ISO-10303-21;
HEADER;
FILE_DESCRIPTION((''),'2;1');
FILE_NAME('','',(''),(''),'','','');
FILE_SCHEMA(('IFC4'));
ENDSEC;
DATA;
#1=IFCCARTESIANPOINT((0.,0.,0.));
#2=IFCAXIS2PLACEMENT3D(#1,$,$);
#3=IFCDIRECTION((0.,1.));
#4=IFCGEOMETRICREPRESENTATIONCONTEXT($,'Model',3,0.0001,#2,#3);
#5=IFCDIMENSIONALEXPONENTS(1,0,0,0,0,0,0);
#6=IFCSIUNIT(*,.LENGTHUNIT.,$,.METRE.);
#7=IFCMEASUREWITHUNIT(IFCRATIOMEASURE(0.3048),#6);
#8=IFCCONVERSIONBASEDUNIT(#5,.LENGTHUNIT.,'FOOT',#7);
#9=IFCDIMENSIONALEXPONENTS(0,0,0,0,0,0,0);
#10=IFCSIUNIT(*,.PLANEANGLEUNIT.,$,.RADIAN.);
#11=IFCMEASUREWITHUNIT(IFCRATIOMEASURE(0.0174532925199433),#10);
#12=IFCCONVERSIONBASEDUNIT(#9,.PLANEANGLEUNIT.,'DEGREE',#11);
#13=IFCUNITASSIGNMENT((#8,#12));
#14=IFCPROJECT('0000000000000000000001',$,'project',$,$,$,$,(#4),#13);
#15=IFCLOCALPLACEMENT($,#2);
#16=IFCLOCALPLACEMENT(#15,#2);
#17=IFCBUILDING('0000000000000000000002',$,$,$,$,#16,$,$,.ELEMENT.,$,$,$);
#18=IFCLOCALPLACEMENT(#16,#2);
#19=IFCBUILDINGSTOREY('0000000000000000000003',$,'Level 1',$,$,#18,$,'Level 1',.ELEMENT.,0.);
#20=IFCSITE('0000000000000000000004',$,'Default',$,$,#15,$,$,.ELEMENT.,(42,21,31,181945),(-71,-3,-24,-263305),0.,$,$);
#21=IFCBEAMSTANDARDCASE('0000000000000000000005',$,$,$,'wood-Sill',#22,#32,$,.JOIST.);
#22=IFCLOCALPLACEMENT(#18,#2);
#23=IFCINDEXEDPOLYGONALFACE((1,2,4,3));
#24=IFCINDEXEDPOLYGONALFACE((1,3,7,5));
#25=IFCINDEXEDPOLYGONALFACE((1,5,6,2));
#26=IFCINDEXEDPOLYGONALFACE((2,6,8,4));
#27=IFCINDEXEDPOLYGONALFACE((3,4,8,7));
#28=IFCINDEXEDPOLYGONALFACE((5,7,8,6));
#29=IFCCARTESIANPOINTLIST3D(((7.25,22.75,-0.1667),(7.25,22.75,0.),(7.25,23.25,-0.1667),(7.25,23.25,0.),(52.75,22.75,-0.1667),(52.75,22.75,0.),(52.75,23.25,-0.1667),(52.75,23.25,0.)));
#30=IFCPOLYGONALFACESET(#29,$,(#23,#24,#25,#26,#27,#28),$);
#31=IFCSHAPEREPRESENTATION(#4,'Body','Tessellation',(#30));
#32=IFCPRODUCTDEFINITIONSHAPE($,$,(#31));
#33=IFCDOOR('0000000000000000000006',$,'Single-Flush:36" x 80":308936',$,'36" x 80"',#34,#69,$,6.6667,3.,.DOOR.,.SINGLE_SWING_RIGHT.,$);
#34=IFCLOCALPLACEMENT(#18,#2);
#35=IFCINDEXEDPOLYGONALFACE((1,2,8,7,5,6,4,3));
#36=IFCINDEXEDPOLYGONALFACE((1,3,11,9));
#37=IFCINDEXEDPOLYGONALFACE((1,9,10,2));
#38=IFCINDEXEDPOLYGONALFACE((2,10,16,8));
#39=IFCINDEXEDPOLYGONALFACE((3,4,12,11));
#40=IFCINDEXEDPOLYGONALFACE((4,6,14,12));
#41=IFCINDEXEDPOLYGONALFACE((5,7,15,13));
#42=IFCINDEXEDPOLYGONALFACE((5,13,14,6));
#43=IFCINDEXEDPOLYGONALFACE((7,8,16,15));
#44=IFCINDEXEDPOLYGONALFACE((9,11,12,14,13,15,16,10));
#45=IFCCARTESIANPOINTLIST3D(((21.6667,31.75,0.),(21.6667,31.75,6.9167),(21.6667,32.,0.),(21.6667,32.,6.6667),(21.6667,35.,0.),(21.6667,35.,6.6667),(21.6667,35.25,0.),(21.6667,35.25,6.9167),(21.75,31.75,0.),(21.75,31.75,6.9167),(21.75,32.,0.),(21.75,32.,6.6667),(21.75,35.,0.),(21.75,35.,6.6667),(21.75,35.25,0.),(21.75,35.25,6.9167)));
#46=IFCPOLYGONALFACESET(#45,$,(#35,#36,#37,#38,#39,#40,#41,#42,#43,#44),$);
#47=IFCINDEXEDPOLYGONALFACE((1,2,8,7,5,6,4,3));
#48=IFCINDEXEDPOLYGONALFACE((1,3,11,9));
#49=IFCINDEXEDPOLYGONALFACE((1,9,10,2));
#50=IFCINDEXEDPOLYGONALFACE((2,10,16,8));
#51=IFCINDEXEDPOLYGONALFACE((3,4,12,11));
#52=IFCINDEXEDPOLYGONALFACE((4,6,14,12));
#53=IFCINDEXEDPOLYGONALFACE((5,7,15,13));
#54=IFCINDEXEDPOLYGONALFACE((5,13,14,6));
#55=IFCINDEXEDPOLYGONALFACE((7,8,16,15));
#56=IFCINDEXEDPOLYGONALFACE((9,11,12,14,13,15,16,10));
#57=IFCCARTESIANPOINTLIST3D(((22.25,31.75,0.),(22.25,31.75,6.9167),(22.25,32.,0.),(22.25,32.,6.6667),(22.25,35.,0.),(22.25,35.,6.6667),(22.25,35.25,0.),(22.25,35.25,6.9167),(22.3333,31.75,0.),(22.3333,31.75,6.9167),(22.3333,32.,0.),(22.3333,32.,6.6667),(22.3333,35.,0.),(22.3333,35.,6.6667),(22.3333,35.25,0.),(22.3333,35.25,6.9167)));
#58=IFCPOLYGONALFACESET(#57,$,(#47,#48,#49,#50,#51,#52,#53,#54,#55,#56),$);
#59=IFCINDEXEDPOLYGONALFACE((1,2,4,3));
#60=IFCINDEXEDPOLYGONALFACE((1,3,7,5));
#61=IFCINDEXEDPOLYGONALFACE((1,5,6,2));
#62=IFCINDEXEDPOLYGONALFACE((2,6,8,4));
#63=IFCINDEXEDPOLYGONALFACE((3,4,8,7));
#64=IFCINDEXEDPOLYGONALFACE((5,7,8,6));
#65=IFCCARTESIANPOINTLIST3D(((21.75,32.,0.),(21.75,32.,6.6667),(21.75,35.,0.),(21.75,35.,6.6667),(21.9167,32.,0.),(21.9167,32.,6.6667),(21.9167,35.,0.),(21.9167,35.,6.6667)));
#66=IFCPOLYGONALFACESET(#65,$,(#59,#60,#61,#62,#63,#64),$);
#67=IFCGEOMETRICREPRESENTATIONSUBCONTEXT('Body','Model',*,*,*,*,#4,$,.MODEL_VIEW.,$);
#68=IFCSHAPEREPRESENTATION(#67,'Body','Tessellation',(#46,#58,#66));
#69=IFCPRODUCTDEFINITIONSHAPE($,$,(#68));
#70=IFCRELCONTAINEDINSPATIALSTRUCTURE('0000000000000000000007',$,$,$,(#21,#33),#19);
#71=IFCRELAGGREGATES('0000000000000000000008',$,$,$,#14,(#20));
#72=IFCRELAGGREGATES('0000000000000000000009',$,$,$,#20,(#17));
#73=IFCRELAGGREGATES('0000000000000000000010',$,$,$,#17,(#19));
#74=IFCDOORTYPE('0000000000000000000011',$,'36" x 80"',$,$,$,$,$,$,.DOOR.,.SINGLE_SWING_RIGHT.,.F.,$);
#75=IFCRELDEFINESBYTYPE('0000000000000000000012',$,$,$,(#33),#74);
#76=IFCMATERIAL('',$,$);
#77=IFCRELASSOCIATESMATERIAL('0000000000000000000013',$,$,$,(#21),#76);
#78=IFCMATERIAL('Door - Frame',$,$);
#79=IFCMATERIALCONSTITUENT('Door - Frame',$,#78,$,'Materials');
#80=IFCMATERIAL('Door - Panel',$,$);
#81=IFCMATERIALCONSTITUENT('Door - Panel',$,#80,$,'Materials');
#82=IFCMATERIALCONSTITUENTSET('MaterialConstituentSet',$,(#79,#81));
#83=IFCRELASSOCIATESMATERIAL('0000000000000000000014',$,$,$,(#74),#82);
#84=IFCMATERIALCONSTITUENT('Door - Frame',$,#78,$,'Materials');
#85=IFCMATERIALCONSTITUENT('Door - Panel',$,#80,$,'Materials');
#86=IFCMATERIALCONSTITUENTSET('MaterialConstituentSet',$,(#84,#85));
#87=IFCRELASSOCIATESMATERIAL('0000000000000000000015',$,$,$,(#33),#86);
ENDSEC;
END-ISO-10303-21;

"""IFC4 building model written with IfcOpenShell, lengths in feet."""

from ifc_helpers import new_model, entity, si_unit, converted_unit, direction, frame, origin, origin_2d_with_axis, place, context, subcontext, project, spatial, polyline, rectangle, outline, extrude, source, transform, mapped, material, constituent, constituent_set, type_object, type_shapes, element, save


model = new_model("IFC4")

# Units and contexts
model_context = context("Model", 3, precision=0.0001, world=origin(), true_north=direction((0.0, 1.0)))
body_context = subcontext(model_context, "Body", "Model", "MODEL_VIEW")
ifc_project = project(units=[converted_unit("LENGTHUNIT", "FOOT", entity("IfcRatioMeasure", 0.3048), si_unit("LENGTHUNIT", "METRE"), dimensions=[1, 0, 0, 0, 0, 0, 0]), converted_unit("PLANEANGLEUNIT", "DEGREE", entity("IfcRatioMeasure", 0.0174532925199433), si_unit("PLANEANGLEUNIT", "RADIAN"), dimensions=[0, 0, 0, 0, 0, 0, 0])], contexts=[model_context])

# Site, building, storey
site_placement = place(None, origin())
site = spatial("IfcSite", under=ifc_project, at=site_placement, Name="Default", CompositionType="ELEMENT", RefLatitude=(42, 21, 31, 181945), RefLongitude=(-71, -3, -24, -263305), RefElevation=0.0)
building_placement = place(site_placement, origin())
building = spatial("IfcBuilding", under=site, at=building_placement, CompositionType="ELEMENT")
storey_placement = place(building_placement, origin())
storey = spatial("IfcBuildingStorey", under=building, at=storey_placement, Name="Level 1", LongName="Level 1", CompositionType="ELEMENT", Elevation=0.0)

# Shared definitions
placement_1 = place(storey_placement, frame((30.0, 45.75, 0.0), z_axis=(0.0, 0.0, 1.0), x_axis=(0.0, -1.0, 0.0)))

# Beam
ifc_material_1 = material(Name="")
beam_1_placement = place(placement_1, frame((22.75, 0.0, -0.1667), z_axis=(0.0, 0.0, 1.0), x_axis=(0.0, -1.0, 0.0)))
element("IfcBeamStandardCase", 1, at=beam_1_placement, inside=storey, material=ifc_material_1, ObjectType="wood-Sill", PredefinedType="JOIST", context=model_context, shape_type="SweptSolid", body=[
    extrude(rectangle(XDim=45.5, YDim=0.5), origin(), (0.0, 0.0, 1.0), 0.1667),
])

# Door
ifc_material_2 = material(Name="Door - Frame")
ifc_constituent_1 = constituent(ifc_material_2, Name="Door - Frame", Category="Materials")
ifc_material_3 = material(Name="Door - Panel")
ifc_constituent_2 = constituent(ifc_material_3, Name="Door - Panel", Category="Materials")
ifc_constituent_set_1 = constituent_set(constituents=[ifc_constituent_1, ifc_constituent_2], Name="MaterialConstituentSet")
ifc_constituent_3 = constituent(ifc_material_2, Name="Door - Frame", Category="Materials")
ifc_constituent_4 = constituent(ifc_material_3, Name="Door - Panel", Category="Materials")
ifc_constituent_set_2 = constituent_set(constituents=[ifc_constituent_3, ifc_constituent_4], Name="MaterialConstituentSet")
door_type = type_object("IfcDoorType", Name="36\" x 80\"", OperationType="SINGLE_SWING_RIGHT", ParameterTakesPrecedence=False, PredefinedType="DOOR", material=ifc_constituent_set_2)
shared_shape = source(origin(), body_context, "Body", "SweptSolid", [
    extrude(outline(polyline([(-1.75, -3.5208), (1.75, -3.5208), (1.75, 3.3958), (1.5, 3.3958), (1.5, -3.2708), (-1.5, -3.2708), (-1.5, 3.3958), (-1.75, 3.3958), (-1.75, -3.5208)])), frame((1.5, 0.5, 3.3958), z_axis=(0.0, 1.0, 0.0), x_axis=(1.0, 0.0, 0.0)), (0.0, 0.0, 1.0), 0.0833),
    extrude(outline(polyline([(-3.5208, -1.75), (3.3958, -1.75), (3.3958, -1.5), (-3.2708, -1.5), (-3.2708, 1.5), (3.3958, 1.5), (3.3958, 1.75), (-3.5208, 1.75), (-3.5208, -1.75)])), frame((1.5, -0.0833, 3.3958), z_axis=(0.0, 1.0, 0.0), x_axis=(0.0, 0.0, -1.0)), (0.0, 0.0, 1.0), 0.0833),
    extrude(rectangle(XDim=0.1667, YDim=3.0, at=origin_2d_with_axis()), frame((1.5, 0.4167, 0.0), z_axis=(0.0, 0.0, 1.0), x_axis=(0.0, 1.0, 0.0)), (0.0, 0.0, 1.0), 6.6667),
])
type_shapes(door_type, [shared_shape])
placement_2 = place(storey_placement, frame((22.0, 45.75, 0.0), z_axis=(0.0, 0.0, 1.0), x_axis=(0.0, -1.0, 0.0)))
placement_3 = place(placement_2, frame((13.75, 0.25, 0.0)))
door_placement = place(placement_3, frame((0.0, 0.0, 0.0), z_axis=(0.0, 0.0, 1.0), x_axis=(-1.0, 0.0, 0.0)))
element("IfcDoor", 2, at=door_placement, inside=storey, type_object=door_type, material=ifc_constituent_set_1, Name="Single-Flush:36\" x 80\":308936", ObjectType="36\" x 80\"", OperationType="SINGLE_SWING_RIGHT", OverallHeight=6.6667, OverallWidth=3.0, PredefinedType="DOOR", context=body_context, shape_type="MappedRepresentation", body=[
    mapped(shared_shape, transform((0.0, 0.0, 0.0), scale=1.0)),
])

save(model, "model.ifc")
